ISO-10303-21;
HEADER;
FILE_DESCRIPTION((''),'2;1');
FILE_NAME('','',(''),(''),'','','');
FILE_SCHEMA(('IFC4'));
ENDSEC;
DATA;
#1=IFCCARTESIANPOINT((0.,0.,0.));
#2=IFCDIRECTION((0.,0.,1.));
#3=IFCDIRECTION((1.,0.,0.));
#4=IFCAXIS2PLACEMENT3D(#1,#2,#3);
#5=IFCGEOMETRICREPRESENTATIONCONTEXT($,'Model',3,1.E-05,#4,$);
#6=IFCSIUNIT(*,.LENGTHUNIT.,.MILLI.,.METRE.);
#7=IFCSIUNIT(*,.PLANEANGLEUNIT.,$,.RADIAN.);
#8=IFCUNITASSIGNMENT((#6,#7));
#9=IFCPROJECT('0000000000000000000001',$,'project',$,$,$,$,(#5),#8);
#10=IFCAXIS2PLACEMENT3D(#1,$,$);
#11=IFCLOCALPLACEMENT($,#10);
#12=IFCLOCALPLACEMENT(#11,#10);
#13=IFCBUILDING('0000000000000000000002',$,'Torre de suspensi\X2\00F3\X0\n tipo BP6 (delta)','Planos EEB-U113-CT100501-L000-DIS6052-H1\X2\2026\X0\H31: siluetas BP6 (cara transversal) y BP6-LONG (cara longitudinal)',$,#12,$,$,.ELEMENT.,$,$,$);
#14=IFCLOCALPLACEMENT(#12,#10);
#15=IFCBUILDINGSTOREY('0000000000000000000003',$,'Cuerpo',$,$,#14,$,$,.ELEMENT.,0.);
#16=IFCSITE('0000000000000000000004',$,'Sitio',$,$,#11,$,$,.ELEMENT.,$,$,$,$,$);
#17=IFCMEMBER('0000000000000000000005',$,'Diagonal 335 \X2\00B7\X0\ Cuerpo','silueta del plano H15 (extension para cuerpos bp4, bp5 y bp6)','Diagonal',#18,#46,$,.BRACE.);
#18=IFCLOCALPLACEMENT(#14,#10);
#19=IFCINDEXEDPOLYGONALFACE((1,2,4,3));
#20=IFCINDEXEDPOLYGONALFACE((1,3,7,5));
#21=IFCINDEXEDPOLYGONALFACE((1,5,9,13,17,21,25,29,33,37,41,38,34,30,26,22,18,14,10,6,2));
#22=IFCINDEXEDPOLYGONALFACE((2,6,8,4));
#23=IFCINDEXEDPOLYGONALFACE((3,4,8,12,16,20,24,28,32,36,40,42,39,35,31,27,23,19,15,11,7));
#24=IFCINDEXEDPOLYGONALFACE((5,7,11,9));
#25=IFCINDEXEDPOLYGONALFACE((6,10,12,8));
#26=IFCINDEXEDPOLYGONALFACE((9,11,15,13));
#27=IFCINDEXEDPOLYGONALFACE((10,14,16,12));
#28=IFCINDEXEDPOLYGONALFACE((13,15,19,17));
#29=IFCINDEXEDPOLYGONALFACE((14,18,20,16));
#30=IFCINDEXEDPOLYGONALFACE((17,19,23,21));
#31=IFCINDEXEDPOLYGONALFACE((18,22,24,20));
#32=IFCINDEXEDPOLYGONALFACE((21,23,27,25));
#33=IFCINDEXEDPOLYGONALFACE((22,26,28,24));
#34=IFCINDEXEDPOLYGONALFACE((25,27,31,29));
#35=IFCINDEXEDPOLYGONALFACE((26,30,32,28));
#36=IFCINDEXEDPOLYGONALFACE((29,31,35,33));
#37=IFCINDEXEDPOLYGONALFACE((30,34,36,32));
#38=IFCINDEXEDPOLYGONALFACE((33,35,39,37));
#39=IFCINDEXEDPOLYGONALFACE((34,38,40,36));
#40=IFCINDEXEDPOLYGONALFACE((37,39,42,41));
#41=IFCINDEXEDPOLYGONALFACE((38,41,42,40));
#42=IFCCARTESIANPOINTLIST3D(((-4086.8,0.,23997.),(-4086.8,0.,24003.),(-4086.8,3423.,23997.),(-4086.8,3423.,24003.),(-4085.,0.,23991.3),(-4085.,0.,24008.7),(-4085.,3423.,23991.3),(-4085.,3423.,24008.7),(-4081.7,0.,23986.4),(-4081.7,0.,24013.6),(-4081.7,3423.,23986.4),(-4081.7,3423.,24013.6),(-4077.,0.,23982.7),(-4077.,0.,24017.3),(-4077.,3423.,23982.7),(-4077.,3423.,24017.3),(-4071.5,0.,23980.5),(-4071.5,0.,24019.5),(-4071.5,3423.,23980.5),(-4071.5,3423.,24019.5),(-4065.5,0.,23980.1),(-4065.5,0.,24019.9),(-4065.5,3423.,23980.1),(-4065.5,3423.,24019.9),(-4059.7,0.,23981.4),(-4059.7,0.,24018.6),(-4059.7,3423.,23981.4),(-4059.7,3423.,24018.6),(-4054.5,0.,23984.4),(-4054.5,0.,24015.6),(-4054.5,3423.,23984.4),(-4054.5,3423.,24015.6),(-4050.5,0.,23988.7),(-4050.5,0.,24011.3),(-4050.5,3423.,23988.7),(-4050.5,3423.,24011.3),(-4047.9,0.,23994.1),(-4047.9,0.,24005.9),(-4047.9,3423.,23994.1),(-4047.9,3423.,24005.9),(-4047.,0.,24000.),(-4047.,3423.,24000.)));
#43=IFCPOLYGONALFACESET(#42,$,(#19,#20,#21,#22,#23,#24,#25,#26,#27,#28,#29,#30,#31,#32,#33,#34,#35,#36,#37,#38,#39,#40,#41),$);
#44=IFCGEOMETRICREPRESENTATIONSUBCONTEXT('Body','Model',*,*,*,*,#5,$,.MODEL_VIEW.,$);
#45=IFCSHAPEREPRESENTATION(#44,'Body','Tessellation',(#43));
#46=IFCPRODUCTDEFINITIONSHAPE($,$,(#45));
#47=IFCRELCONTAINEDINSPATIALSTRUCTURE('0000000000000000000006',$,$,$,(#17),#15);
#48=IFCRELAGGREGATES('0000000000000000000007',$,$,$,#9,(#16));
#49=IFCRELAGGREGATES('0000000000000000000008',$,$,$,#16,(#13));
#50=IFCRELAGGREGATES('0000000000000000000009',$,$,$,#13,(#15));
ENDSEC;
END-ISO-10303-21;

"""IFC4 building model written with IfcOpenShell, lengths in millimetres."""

from ifc_helpers import new_model, si_unit, frame, origin, origin_with_axes, place, context, subcontext, project, spatial, circle, extrude, element, save


model = new_model("IFC4")

# Units and contexts
model_context = context("Model", 3, precision=1e-05, world=origin_with_axes())
body_context = subcontext(model_context, "Body", "Model", "MODEL_VIEW")
ifc_project = project(units=[si_unit("LENGTHUNIT", "METRE", prefix="MILLI"), si_unit("PLANEANGLEUNIT", "RADIAN")], contexts=[model_context])

# Site, building, storey
site_placement = place(None, origin())
site = spatial("IfcSite", under=ifc_project, at=site_placement, Name="Sitio", CompositionType="ELEMENT")
building_placement = place(site_placement, origin())
building = spatial("IfcBuilding", under=site, at=building_placement, Name="Torre de suspensión tipo BP6 (delta)", Description="Planos EEB-U113-CT100501-L000-DIS6052-H1…H31: siluetas BP6 (cara transversal) y BP6-LONG (cara longitudinal)", CompositionType="ELEMENT")
storey_placement = place(building_placement, origin())
storey = spatial("IfcBuildingStorey", under=building, at=storey_placement, Name="Cuerpo", CompositionType="ELEMENT", Elevation=0.0)

# Member
for number, where, z_axis, x_axis, name in (
    (1, (-4067.0, 3423.0, 24000.0), (0.0, -1.0, 0.0), (1.0, 0.0, 0.0), "Diagonal 335 · Cuerpo"),
):
    element("IfcMember", number, at=place(storey_placement, frame(where, z_axis=z_axis, x_axis=x_axis)), inside=storey, Name=name, Description="silueta del plano H15 (extension para cuerpos bp4, bp5 y bp6)", ObjectType="Diagonal", PredefinedType="BRACE", context=body_context, shape_type="SweptSolid", body=[
        extrude(circle(Radius=20.0), None, (0.0, 0.0, 1.0), 3423.0),
    ])

save(model, "model.ifc")
